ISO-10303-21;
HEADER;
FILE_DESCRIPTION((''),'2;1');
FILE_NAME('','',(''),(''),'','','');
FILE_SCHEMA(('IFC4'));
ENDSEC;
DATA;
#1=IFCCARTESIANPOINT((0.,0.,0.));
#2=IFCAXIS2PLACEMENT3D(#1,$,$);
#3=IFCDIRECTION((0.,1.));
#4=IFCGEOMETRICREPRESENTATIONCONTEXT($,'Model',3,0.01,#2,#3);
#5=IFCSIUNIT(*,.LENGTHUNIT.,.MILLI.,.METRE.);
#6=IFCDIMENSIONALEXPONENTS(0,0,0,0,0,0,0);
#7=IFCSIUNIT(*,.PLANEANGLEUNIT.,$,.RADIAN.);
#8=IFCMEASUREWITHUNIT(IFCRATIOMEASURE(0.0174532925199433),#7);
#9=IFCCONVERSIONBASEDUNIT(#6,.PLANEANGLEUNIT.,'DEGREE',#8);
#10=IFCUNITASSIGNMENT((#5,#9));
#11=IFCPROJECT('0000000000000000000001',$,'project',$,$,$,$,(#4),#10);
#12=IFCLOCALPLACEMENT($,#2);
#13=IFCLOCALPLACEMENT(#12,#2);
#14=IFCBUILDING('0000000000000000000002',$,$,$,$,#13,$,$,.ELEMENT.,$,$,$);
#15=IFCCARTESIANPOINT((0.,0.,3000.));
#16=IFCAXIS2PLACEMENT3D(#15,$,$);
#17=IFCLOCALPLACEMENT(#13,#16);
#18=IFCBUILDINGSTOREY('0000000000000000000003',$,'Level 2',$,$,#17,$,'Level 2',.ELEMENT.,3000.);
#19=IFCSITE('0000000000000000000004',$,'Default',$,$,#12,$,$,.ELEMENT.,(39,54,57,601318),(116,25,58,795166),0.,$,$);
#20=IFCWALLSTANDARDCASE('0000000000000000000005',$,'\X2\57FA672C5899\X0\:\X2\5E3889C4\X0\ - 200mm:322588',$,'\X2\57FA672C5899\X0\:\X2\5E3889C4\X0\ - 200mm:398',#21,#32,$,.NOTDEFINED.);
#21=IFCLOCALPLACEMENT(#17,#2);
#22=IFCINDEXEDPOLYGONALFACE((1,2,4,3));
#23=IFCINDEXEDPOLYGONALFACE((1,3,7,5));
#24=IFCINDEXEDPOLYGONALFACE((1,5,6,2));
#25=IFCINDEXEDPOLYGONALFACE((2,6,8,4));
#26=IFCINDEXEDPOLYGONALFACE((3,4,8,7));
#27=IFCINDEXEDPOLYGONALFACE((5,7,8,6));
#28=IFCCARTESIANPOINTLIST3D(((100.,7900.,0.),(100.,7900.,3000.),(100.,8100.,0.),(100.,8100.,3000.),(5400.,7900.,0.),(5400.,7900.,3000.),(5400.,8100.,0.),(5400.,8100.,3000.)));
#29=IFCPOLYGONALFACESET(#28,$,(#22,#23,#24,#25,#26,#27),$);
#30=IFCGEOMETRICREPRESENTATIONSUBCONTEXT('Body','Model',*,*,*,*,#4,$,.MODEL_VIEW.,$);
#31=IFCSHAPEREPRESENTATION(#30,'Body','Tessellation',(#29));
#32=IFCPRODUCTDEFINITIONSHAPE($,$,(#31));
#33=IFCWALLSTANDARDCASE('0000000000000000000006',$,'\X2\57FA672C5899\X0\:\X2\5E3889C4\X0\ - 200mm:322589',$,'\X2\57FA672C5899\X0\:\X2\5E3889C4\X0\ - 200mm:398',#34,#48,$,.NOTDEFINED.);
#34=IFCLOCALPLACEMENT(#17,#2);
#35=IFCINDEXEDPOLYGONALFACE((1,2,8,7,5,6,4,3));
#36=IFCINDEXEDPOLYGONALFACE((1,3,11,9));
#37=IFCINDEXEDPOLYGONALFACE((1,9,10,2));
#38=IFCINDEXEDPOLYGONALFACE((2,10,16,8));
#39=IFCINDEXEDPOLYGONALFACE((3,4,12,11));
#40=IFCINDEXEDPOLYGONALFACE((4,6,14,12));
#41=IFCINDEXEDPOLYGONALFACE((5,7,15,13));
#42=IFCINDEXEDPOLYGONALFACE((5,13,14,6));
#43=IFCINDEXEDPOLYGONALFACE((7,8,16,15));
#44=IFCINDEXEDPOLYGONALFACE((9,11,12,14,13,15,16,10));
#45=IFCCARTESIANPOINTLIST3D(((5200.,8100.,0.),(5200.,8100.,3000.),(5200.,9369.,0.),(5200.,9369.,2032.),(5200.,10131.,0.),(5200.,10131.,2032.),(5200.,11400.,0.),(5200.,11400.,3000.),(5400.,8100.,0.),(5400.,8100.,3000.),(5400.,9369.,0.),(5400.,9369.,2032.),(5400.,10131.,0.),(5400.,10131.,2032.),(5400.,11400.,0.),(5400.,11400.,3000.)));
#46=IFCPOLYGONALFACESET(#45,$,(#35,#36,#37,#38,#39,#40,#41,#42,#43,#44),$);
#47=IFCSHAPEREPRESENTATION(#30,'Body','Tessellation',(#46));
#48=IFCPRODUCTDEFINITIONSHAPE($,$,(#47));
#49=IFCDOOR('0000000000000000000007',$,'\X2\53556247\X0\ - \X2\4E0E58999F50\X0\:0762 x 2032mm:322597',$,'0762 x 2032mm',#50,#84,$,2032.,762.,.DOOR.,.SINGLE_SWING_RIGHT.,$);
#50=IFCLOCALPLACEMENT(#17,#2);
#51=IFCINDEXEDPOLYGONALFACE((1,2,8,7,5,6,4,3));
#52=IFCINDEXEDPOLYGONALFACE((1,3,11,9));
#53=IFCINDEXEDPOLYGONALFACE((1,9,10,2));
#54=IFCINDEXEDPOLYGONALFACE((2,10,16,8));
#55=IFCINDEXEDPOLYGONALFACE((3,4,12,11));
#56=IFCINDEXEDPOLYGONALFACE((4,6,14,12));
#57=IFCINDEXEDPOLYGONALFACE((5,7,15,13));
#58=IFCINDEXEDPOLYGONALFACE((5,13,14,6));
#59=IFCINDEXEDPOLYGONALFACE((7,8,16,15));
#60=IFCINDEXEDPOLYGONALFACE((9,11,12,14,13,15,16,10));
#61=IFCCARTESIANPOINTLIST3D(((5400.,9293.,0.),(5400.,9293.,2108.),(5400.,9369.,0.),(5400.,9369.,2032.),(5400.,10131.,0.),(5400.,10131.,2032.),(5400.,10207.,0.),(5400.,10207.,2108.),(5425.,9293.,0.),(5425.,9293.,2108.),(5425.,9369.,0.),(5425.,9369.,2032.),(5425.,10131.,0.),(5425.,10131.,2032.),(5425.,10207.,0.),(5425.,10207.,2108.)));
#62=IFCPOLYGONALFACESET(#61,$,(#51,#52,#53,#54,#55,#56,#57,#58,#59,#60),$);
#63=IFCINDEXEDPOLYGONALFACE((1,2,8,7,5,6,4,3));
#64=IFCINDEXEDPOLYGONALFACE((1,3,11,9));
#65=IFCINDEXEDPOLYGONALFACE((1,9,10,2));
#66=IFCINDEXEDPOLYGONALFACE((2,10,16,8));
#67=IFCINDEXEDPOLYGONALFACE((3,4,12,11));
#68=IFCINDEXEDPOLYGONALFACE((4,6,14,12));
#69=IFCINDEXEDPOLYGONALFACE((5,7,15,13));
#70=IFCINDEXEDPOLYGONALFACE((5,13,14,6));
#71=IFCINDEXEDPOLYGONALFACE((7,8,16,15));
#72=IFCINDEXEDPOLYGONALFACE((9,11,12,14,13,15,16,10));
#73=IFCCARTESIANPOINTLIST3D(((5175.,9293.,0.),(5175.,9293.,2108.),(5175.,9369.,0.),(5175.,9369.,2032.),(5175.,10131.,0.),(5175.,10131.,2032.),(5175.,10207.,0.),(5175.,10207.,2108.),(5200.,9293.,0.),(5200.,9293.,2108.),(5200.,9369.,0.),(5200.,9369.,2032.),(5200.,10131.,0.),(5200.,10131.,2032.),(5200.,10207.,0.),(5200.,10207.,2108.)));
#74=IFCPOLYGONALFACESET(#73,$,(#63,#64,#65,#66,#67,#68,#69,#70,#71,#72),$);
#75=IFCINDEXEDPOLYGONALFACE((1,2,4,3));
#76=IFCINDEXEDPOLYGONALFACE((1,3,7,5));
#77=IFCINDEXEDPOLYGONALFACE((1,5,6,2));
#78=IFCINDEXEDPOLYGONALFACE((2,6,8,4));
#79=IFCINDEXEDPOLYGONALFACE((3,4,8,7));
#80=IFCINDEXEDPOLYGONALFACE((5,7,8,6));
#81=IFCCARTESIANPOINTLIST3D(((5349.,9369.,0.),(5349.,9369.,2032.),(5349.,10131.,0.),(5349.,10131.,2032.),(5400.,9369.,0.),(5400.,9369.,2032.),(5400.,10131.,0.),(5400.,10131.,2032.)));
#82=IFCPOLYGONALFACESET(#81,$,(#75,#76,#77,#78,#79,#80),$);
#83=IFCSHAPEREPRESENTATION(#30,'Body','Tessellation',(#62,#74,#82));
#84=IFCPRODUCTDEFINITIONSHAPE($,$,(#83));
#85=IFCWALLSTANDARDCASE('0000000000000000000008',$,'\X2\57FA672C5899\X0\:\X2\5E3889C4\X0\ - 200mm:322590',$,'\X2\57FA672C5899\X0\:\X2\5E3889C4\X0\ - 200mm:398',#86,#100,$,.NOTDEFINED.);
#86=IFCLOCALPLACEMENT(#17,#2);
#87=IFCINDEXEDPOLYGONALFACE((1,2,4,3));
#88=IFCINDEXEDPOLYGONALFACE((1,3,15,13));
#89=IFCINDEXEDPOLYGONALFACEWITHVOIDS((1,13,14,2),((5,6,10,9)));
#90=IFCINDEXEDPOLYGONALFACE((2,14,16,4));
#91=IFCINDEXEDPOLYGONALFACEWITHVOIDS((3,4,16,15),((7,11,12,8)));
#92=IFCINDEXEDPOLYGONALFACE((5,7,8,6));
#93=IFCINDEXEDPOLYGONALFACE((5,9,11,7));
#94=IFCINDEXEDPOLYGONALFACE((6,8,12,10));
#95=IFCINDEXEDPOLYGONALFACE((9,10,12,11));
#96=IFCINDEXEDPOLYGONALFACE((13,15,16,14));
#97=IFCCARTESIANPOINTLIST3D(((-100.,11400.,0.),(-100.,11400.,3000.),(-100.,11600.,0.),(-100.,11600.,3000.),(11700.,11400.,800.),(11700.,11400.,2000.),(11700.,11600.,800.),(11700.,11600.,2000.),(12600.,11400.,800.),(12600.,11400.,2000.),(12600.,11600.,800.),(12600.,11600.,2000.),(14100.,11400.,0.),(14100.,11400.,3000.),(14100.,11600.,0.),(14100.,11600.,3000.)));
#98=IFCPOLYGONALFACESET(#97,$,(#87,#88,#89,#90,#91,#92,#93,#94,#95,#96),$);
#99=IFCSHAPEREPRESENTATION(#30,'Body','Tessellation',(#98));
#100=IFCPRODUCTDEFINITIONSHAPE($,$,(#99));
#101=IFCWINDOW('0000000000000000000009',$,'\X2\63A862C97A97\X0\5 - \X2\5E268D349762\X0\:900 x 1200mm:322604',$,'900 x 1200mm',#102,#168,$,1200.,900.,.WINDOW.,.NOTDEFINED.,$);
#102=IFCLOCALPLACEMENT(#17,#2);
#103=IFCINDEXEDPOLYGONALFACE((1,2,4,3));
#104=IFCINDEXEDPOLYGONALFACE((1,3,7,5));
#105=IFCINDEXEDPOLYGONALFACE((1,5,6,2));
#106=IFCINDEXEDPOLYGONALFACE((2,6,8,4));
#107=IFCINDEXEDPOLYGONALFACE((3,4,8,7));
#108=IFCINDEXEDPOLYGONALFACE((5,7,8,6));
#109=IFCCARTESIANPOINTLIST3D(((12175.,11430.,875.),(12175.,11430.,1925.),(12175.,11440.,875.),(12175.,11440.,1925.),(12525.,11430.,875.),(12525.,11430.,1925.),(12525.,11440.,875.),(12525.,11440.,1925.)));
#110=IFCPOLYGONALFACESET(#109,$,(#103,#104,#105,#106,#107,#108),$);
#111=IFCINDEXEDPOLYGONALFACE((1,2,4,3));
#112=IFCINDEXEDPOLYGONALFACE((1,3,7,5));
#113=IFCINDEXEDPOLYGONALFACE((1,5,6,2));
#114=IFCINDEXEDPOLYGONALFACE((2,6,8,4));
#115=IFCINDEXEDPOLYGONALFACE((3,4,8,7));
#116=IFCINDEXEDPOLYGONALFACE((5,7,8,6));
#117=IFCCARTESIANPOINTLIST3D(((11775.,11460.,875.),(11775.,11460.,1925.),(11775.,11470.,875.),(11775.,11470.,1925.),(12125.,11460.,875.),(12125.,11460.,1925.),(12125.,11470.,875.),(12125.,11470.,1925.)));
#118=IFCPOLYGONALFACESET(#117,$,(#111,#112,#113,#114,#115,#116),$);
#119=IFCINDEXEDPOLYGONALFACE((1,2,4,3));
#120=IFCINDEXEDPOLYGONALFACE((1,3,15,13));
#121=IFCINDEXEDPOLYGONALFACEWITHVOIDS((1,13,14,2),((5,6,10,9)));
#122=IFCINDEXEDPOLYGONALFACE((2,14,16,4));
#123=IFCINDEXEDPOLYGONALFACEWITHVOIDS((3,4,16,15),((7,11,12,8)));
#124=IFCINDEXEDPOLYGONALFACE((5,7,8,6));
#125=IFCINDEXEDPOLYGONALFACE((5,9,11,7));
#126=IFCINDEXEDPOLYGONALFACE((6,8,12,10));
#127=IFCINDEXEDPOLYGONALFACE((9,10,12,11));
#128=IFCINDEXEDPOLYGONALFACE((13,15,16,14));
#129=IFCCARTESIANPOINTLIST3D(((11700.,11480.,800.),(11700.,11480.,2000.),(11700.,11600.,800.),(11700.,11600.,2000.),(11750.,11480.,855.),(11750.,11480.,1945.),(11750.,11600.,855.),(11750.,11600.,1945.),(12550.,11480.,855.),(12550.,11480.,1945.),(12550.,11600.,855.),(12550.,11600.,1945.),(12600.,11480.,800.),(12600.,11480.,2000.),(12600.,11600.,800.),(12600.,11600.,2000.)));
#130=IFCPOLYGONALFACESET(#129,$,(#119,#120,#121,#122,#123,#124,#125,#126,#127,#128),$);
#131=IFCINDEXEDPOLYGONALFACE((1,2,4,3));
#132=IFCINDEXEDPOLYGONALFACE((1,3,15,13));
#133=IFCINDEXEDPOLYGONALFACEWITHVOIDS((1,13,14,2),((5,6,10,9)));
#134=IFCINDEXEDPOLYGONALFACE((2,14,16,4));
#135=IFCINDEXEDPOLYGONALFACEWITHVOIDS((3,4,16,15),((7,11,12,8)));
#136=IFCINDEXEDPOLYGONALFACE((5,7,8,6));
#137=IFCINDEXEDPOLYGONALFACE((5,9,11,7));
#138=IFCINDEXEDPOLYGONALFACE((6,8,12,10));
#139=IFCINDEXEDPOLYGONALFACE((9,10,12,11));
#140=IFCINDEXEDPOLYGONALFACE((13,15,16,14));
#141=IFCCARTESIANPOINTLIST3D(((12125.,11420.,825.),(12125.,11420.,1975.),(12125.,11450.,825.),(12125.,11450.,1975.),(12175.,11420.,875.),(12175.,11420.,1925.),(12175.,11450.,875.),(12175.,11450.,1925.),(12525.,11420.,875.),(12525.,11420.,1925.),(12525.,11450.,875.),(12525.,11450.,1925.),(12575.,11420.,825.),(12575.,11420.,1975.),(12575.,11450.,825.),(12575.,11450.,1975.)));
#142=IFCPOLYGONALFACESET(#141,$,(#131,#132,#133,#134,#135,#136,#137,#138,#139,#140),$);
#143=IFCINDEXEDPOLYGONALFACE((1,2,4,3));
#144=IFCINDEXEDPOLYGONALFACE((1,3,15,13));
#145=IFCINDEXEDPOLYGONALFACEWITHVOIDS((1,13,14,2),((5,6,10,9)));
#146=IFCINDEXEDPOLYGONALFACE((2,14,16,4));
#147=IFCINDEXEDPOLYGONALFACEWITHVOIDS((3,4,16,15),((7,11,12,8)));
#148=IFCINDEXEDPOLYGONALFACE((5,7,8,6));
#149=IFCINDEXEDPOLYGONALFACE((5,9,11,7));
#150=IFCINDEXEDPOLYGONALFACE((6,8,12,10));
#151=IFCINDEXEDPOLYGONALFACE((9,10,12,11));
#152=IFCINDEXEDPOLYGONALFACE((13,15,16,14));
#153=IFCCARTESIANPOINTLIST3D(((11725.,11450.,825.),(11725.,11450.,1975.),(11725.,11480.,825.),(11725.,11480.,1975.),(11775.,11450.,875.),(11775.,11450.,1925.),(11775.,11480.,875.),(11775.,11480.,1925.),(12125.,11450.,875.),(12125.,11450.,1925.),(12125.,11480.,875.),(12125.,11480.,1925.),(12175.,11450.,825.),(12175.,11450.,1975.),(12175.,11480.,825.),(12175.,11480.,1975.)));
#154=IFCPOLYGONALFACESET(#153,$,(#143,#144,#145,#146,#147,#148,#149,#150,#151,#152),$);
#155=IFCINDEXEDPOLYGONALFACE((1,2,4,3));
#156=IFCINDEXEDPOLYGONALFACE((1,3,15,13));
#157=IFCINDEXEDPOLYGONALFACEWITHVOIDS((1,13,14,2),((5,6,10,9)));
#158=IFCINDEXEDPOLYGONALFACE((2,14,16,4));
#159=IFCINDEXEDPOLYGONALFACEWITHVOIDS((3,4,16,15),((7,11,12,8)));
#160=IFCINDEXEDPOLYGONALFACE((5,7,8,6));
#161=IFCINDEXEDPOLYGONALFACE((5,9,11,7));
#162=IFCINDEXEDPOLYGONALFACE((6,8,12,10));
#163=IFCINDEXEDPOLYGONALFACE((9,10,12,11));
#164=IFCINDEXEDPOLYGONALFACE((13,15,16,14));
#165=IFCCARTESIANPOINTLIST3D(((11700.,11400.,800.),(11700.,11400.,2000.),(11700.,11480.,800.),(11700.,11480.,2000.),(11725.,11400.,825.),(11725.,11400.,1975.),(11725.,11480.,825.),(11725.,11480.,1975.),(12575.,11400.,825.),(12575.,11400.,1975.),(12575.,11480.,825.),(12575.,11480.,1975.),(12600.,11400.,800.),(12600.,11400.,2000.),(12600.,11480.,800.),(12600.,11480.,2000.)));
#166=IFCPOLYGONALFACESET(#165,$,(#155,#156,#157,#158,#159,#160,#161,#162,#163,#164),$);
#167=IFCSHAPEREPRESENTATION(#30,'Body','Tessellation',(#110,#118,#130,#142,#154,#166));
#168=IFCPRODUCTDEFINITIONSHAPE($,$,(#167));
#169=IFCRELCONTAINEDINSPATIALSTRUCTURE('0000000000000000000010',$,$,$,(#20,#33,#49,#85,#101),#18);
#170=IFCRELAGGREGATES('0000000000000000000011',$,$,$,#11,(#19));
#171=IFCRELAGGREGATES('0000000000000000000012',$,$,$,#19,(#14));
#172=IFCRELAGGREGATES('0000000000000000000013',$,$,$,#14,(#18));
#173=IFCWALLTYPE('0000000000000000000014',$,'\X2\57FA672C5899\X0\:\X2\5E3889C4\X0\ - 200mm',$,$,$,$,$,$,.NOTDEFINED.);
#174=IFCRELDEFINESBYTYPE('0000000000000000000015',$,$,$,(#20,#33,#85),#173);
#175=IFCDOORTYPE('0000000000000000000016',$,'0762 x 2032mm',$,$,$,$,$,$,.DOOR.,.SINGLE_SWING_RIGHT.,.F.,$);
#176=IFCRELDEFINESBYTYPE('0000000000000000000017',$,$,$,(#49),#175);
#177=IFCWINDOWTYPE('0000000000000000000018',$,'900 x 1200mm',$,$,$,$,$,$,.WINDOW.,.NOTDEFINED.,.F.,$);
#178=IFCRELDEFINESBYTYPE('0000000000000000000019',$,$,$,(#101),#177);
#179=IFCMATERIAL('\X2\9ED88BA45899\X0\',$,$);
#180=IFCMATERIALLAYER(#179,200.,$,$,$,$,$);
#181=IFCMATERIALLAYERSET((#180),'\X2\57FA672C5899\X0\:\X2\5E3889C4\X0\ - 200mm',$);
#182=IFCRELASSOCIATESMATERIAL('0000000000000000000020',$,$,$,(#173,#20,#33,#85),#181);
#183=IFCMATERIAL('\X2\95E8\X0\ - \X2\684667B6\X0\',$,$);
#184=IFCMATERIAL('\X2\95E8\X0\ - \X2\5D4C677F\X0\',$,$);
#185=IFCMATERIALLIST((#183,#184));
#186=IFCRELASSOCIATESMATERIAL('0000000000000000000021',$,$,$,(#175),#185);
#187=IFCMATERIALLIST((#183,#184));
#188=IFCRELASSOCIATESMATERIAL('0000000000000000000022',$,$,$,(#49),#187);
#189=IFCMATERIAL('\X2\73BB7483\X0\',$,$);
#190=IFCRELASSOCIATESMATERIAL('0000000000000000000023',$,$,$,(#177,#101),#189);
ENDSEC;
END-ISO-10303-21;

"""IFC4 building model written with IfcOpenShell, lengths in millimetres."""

from ifc_helpers import new_model, entity, si_unit, converted_unit, direction, frame, frame_2d, origin, origin_2d_with_axis, place, context, subcontext, project, spatial, polyline, rectangle, outline, extrude, source, transform, mapped, material, material_list, layer, layer_set, layer_usage, type_object, type_shapes, element, fill, save


model = new_model("IFC4")

# Units and contexts
model_context_1 = context("Model", 3, precision=0.01, world=origin(), true_north=direction((0.0, 1.0)))
body_context_1 = subcontext(model_context_1, "Body", "Model", "MODEL_VIEW")
ifc_project = project(units=[si_unit("LENGTHUNIT", "METRE", prefix="MILLI"), converted_unit("PLANEANGLEUNIT", "DEGREE", entity("IfcRatioMeasure", 0.0174532925199433), si_unit("PLANEANGLEUNIT", "RADIAN"), dimensions=[0, 0, 0, 0, 0, 0, 0])], contexts=[model_context_1])

# Site, building, storey
site_placement = place(None, origin())
site = spatial("IfcSite", under=ifc_project, at=site_placement, Name="Default", CompositionType="ELEMENT", RefLatitude=(39, 54, 57, 601318), RefLongitude=(116, 25, 58, 795166), RefElevation=0.0)
building_placement = place(site_placement, origin())
building = spatial("IfcBuilding", under=site, at=building_placement, CompositionType="ELEMENT")
storey_placement = place(building_placement, frame((0.0, 0.0, 3000.0)))
storey = spatial("IfcBuildingStorey", under=building, at=storey_placement, Name="Level 2", LongName="Level 2", CompositionType="ELEMENT", Elevation=3000.0)

# Wall
ifc_material_1 = material(Name="默认墙")
ifc_layer_1 = layer(ifc_material_1, 200.0)
ifc_layer_set_1 = layer_set([ifc_layer_1], Name="基本墙:常规 - 200mm")
ifc_layer_usage_1 = layer_usage(ifc_layer_set_1, "AXIS2", "NEGATIVE", 100.0)
wall_type = type_object("IfcWallType", Name="基本墙:常规 - 200mm", PredefinedType="NOTDEFINED", material=ifc_layer_set_1)
wall_1_placement = place(storey_placement, frame((100.0, 8000.0, 0.0)))
element("IfcWallStandardCase", 1, at=wall_1_placement, inside=storey, type_object=wall_type, material=ifc_layer_usage_1, Name="基本墙:常规 - 200mm:322588", ObjectType="基本墙:常规 - 200mm:398", PredefinedType="NOTDEFINED", context=body_context_1, shape_type="SweptSolid", body=[
    extrude(rectangle(XDim=5300.0, YDim=200.0, at=frame_2d((2650.0, 0.0), x_axis=(-1.0, 0.0))), origin(), (0.0, 0.0, 1.0), 3000.0),
])

# Wall, opening, door
ifc_layer_usage_2 = layer_usage(ifc_layer_set_1, "AXIS2", "NEGATIVE", 100.0)
wall_2_placement = place(storey_placement, frame((5300.0, 8100.0, 0.0), z_axis=(0.0, 0.0, 1.0), x_axis=(0.0, 1.0, 0.0)))
wall_2 = element("IfcWallStandardCase", 2, at=wall_2_placement, inside=storey, type_object=wall_type, material=ifc_layer_usage_2, Name="基本墙:常规 - 200mm:322589", ObjectType="基本墙:常规 - 200mm:398", PredefinedType="NOTDEFINED", context=body_context_1, shape_type="SweptSolid", body=[
    extrude(rectangle(XDim=3300.0, YDim=200.0, at=frame_2d((1650.0, 0.0), x_axis=(-1.0, 0.0))), origin(), (0.0, 0.0, 1.0), 3000.0),
])
opening_1_placement = place(wall_2_placement, frame((2031.0, 100.0, 0.0)))
opening_1 = element("IfcOpeningElement", 3, at=opening_1_placement, cuts=wall_2, ObjectType="Opening", PredefinedType="OPENING", context=body_context_1, shape_type="SweptSolid", body=[
    extrude(rectangle(XDim=762.0, YDim=2032.0, at=frame_2d((1016.0, 381.0), x_axis=(0.0, 1.0))), frame((0.0, 0.0, 0.0), z_axis=(0.0, -1.0, 0.0), x_axis=(0.0, 0.0, 1.0)), (0.0, 0.0, 1.0), 200.0),
])
ifc_material_2 = material(Name="门 - 框架")
ifc_material_3 = material(Name="门 - 嵌板")
ifc_material_list_1 = material_list([ifc_material_2, ifc_material_3])
ifc_material_list_2 = material_list([ifc_material_2, ifc_material_3])
door_type = type_object("IfcDoorType", Name="0762 x 2032mm", OperationType="SINGLE_SWING_RIGHT", ParameterTakesPrecedence=False, PredefinedType="DOOR", material=ifc_material_list_2)
shared_shape_1 = source(origin(), body_context_1, "Body", "SweptSolid", [
    extrude(outline(polyline([(-457.0, -1073.0), (457.0, -1073.0), (457.0, 1035.0), (381.0, 1035.0), (381.0, -997.0), (-381.0, -997.0), (-381.0, 1035.0), (-457.0, 1035.0), (-457.0, -1073.0)])), frame((381.0, 200.0, 1035.0), z_axis=(0.0, 1.0, 0.0), x_axis=(1.0, 0.0, 0.0)), (0.0, 0.0, 1.0), 25.0),
    extrude(outline(polyline([(-1073.0, -457.0), (1035.0, -457.0), (1035.0, -381.0), (-997.0, -381.0), (-997.0, 381.0), (1035.0, 381.0), (1035.0, 457.0), (-1073.0, 457.0), (-1073.0, -457.0)])), frame((381.0, -25.0, 1035.0), z_axis=(0.0, 1.0, 0.0), x_axis=(0.0, 0.0, -1.0)), (0.0, 0.0, 1.0), 25.0),
    extrude(rectangle(XDim=51.0, YDim=762.0, at=frame_2d((0.0, 0.0), x_axis=(1.0, 0.0))), frame((381.0, 174.5, 0.0), z_axis=(0.0, 0.0, 1.0), x_axis=(0.0, 1.0, 0.0)), (0.0, 0.0, 1.0), 2032.0),
])
type_shapes(door_type, [shared_shape_1])
door_placement = place(opening_1_placement, frame((0.0, 0.0, 0.0), z_axis=(0.0, 0.0, 1.0), x_axis=(-1.0, 0.0, 0.0)))
door = element("IfcDoor", 4, at=door_placement, inside=storey, type_object=door_type, material=ifc_material_list_1, Name="单扇 - 与墙齐:0762 x 2032mm:322597", ObjectType="0762 x 2032mm", OperationType="SINGLE_SWING_RIGHT", OverallHeight=2032.0, OverallWidth=762.0, PredefinedType="DOOR", context=body_context_1, shape_type="MappedRepresentation", body=[
    mapped(shared_shape_1, transform((0.0, 0.0, 0.0), scale=1.0)),
])
fill(opening_1, door)

# Wall, opening, window
ifc_layer_usage_3 = layer_usage(ifc_layer_set_1, "AXIS2", "NEGATIVE", 100.0)
wall_3_placement = place(storey_placement, frame((-100.0, 11500.0, 0.0)))
wall_3 = element("IfcWallStandardCase", 5, at=wall_3_placement, inside=storey, type_object=wall_type, material=ifc_layer_usage_3, Name="基本墙:常规 - 200mm:322590", ObjectType="基本墙:常规 - 200mm:398", PredefinedType="NOTDEFINED", context=body_context_1, shape_type="SweptSolid", body=[
    extrude(rectangle(XDim=14200.0, YDim=200.0, at=frame_2d((7100.0, 0.0), x_axis=(-1.0, 0.0))), origin(), (0.0, 0.0, 1.0), 3000.0),
])
opening_2_placement = place(wall_3_placement, frame((12700.0, 100.0, 800.0)))
opening_2 = element("IfcOpeningElement", 6, at=opening_2_placement, cuts=wall_3, ObjectType="Opening", PredefinedType="OPENING", context=body_context_1, shape_type="SweptSolid", body=[
    extrude(rectangle(XDim=1200.0, YDim=900.0, at=frame_2d((600.0, 450.0), x_axis=(-1.0, 0.0))), frame((0.0, 0.0, 0.0), z_axis=(0.0, -1.0, 0.0), x_axis=(0.0, 0.0, 1.0)), (0.0, 0.0, 1.0), 200.0),
])
ifc_material_4 = material(Name="玻璃")
window_type = type_object("IfcWindowType", Name="900 x 1200mm", ParameterTakesPrecedence=False, PartitioningType="NOTDEFINED", PredefinedType="WINDOW", material=ifc_material_4)
shared_shape_2 = source(origin(), body_context_1, "Body", "SweptSolid", [
    extrude(rectangle(XDim=10.0, YDim=350.0, at=origin_2d_with_axis()), frame((250.0, 165.0, 75.0), z_axis=(0.0, 0.0, 1.0), x_axis=(0.0, -1.0, 0.0)), (0.0, 0.0, 1.0), 1050.0),
    extrude(rectangle(XDim=10.0, YDim=350.0, at=frame_2d((0.0, 0.0), x_axis=(1.0, 0.0))), frame((650.0, 135.0, 75.0), z_axis=(0.0, 0.0, 1.0), x_axis=(0.0, -1.0, 0.0)), (0.0, 0.0, 1.0), 1050.0),
    extrude(outline(polyline([(-450.0, -600.0), (450.0, -600.0), (450.0, 600.0), (-450.0, 600.0), (-450.0, -600.0)]), holes=[polyline([(400.0, -545.0), (-400.0, -545.0), (-400.0, 545.0), (400.0, 545.0), (400.0, -545.0)])]), frame((450.0, 0.0, 600.0), z_axis=(0.0, 1.0, 0.0), x_axis=(1.0, 0.0, 0.0)), (0.0, 0.0, 1.0), 120.0),
    extrude(outline(polyline([(-225.0, -575.0), (225.0, -575.0), (225.0, 575.0), (-225.0, 575.0), (-225.0, -575.0)]), holes=[polyline([(-175.0, -525.0), (-175.0, 525.0), (175.0, 525.0), (175.0, -525.0), (-175.0, -525.0)])]), frame((250.0, 150.0, 600.0), z_axis=(0.0, 1.0, 0.0), x_axis=(-1.0, 0.0, 0.0)), (0.0, 0.0, 1.0), 30.0),
    extrude(outline(polyline([(-225.0, -575.0), (225.0, -575.0), (225.0, 575.0), (-225.0, 575.0), (-225.0, -575.0)]), holes=[polyline([(-175.0, -525.0), (-175.0, 525.0), (175.0, 525.0), (175.0, -525.0), (-175.0, -525.0)])]), frame((650.0, 120.0, 600.0), z_axis=(0.0, 1.0, 0.0), x_axis=(1.0, 0.0, 0.0)), (0.0, 0.0, 1.0), 30.0),
    extrude(outline(polyline([(-450.0, -600.0), (450.0, -600.0), (450.0, 600.0), (-450.0, 600.0), (-450.0, -600.0)]), holes=[polyline([(-425.0, 575.0), (425.0, 575.0), (425.0, -575.0), (-425.0, -575.0), (-425.0, 575.0)])]), frame((450.0, 120.0, 600.0), z_axis=(0.0, 1.0, 0.0), x_axis=(1.0, 0.0, 0.0)), (0.0, 0.0, 1.0), 80.0),
])
type_shapes(window_type, [shared_shape_2])
window_1_placement = place(opening_2_placement, frame((0.0, 0.0, 0.0), z_axis=(0.0, 0.0, 1.0), x_axis=(-1.0, 0.0, 0.0)))
window_1 = element("IfcWindow", 7, at=window_1_placement, inside=storey, type_object=window_type, material=ifc_material_4, Name="推拉窗5 - 带贴面:900 x 1200mm:322604", ObjectType="900 x 1200mm", OverallHeight=1200.0, OverallWidth=900.0, PartitioningType="NOTDEFINED", PredefinedType="WINDOW", context=body_context_1, shape_type="MappedRepresentation", body=[
    mapped(shared_shape_2, transform((0.0, 0.0, 0.0), scale=1.0)),
])
fill(opening_2, window_1)

save(model, "model.ifc")
